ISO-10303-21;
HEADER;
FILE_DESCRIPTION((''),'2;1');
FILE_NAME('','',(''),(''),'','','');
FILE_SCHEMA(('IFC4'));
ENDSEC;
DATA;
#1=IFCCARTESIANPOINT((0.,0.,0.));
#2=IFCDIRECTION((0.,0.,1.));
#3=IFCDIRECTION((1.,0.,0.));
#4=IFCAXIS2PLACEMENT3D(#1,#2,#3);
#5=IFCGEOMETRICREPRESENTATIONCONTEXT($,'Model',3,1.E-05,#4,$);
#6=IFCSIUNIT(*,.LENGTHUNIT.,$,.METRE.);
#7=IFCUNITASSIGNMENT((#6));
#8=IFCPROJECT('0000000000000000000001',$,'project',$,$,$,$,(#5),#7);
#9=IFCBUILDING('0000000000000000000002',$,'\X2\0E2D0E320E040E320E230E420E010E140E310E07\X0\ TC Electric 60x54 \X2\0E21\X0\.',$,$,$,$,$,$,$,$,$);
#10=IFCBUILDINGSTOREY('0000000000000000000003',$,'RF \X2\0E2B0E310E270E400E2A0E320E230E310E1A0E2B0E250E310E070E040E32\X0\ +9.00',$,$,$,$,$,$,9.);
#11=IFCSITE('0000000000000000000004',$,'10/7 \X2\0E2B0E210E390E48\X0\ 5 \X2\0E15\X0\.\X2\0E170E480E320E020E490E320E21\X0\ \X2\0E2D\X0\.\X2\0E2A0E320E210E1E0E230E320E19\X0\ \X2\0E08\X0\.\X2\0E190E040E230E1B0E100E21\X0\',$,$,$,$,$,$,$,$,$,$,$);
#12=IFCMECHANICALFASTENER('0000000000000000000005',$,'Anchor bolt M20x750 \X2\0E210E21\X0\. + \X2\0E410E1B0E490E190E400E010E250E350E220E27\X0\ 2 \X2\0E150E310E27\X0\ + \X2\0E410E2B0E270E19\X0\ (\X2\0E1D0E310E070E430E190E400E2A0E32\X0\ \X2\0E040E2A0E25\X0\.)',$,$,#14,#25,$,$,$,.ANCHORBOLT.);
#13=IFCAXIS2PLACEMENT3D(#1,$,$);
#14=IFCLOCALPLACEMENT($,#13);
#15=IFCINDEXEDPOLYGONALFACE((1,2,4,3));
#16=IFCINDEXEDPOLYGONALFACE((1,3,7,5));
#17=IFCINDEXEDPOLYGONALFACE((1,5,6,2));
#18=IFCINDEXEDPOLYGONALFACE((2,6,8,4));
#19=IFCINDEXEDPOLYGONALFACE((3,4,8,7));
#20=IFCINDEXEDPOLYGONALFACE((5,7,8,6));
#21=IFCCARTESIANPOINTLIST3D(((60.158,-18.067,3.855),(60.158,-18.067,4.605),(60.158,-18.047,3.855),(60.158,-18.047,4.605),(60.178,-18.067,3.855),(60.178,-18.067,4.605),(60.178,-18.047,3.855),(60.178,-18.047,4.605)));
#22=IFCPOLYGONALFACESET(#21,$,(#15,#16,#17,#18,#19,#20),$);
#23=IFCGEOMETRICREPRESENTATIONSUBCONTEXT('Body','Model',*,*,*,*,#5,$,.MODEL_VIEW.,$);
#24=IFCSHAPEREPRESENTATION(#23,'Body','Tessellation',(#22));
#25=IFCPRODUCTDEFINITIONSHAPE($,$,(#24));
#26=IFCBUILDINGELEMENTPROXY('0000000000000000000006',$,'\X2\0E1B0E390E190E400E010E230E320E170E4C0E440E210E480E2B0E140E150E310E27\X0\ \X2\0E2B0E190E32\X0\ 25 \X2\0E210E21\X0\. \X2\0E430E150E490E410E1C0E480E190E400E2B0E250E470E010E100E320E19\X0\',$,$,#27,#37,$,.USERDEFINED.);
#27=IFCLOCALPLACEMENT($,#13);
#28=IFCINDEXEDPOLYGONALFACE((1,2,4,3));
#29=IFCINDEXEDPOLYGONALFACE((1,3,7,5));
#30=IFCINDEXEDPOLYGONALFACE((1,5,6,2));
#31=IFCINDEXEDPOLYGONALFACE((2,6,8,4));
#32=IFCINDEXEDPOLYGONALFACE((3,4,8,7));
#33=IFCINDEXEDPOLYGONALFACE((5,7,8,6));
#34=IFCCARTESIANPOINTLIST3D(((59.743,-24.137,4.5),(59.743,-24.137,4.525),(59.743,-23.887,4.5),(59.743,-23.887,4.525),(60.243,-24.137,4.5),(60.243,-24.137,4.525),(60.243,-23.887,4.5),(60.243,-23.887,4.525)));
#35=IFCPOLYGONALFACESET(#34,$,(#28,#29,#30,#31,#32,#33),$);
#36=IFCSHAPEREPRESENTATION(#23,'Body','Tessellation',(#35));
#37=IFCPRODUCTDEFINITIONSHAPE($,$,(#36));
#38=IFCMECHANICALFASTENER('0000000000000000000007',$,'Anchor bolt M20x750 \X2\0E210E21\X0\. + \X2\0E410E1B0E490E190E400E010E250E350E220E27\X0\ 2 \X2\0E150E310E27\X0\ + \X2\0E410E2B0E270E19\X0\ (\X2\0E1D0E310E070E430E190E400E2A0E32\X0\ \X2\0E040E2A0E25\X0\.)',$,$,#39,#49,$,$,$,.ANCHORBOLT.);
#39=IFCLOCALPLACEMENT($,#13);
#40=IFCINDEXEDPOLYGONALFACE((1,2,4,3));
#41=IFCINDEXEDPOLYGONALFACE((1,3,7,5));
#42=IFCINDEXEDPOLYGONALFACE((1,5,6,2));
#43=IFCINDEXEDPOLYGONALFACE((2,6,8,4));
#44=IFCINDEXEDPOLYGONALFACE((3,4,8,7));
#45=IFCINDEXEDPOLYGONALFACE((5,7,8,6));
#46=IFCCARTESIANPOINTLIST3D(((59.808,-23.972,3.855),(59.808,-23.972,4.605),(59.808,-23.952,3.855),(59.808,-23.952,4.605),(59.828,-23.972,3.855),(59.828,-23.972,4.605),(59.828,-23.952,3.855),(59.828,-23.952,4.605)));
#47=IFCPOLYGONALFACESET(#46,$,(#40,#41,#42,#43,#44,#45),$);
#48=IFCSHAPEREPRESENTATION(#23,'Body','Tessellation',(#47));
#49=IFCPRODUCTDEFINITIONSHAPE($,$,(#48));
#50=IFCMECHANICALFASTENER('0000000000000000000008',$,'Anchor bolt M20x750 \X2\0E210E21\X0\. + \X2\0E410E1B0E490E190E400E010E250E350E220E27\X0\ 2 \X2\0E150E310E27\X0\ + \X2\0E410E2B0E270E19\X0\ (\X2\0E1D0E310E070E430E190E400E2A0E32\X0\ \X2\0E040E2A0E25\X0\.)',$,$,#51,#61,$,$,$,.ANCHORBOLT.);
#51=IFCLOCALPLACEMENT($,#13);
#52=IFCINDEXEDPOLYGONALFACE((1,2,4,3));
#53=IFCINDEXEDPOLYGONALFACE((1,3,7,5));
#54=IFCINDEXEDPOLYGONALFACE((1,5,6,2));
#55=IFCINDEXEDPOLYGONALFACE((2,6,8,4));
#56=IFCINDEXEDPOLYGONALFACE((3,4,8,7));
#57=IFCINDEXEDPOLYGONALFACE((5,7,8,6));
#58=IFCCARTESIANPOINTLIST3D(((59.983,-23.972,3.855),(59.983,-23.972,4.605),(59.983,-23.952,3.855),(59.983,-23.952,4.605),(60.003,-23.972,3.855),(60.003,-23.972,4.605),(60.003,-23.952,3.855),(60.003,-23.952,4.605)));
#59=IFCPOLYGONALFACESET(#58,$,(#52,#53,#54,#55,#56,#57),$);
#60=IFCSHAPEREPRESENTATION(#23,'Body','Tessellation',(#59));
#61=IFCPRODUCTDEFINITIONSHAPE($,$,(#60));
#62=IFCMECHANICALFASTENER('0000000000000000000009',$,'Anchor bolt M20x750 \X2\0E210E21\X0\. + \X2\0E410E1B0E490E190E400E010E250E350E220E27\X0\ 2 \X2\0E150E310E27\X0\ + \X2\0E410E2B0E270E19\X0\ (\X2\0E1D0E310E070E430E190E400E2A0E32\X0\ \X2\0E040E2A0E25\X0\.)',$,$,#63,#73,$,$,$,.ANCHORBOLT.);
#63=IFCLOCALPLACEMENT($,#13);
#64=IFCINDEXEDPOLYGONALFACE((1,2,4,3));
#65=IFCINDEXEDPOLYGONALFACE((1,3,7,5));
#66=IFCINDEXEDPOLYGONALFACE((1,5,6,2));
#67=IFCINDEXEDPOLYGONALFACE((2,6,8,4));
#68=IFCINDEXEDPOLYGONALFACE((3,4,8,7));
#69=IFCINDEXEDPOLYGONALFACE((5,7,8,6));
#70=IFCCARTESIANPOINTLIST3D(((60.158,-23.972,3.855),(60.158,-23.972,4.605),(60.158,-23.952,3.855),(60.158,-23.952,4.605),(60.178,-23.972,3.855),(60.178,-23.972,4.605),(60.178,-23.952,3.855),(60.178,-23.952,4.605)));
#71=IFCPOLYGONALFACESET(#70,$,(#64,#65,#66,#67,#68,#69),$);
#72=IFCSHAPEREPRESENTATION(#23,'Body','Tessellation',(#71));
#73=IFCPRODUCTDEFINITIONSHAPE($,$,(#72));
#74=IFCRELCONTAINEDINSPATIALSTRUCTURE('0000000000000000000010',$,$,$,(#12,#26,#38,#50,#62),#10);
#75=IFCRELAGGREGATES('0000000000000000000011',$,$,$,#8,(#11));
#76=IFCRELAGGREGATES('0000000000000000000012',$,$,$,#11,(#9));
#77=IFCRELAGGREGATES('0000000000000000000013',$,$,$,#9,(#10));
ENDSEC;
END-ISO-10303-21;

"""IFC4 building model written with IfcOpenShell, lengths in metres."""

from ifc_helpers import new_model, si_unit, frame, origin, origin_with_axes, origin_2d, place, context, subcontext, project, spatial, rectangle, extrude, element, save


model = new_model("IFC4")

# Units and contexts
model_context = context("Model", 3, precision=1e-05, world=origin_with_axes())
body_context = subcontext(model_context, "Body", "Model", "MODEL_VIEW")
ifc_project = project(units=[si_unit("LENGTHUNIT", "METRE")], contexts=[model_context])

# Site, building, storey
site = spatial("IfcSite", under=ifc_project, Name="10/7 หมู่ 5 ต.ท่าข้าม อ.สามพราน จ.นครปฐม")
building = spatial("IfcBuilding", under=site, Name="อาคารโกดัง TC Electric 60x54 ม.")
storey = spatial("IfcBuildingStorey", under=building, Name="RF หัวเสารับหลังคา +9.00", Elevation=9.0)

# Mechanical fastener
for number, where, z_axis, x_axis, name in (
    (1, (60.168, -18.057, 3.855), (0.0, 0.0, 1.0), (1.0, 0.0, 0.0), "Anchor bolt M20x750 มม. + แป้นเกลียว 2 ตัว + แหวน (ฝังในเสา คสล.)"),
):
    element("IfcMechanicalFastener", number, at=place(None, frame(where, z_axis=z_axis, x_axis=x_axis)), inside=storey, Name=name, PredefinedType="ANCHORBOLT", context=body_context, shape_type="SweptSolid", body=[
        extrude(rectangle(XDim=0.02, YDim=0.02, at=origin_2d()), origin(), (0.0, 0.0, 1.0), 0.75),
    ])

# Building element proxy
proxy_1_placement = place(None, frame((59.993, -24.012, 4.5), z_axis=(0.0, 0.0, 1.0), x_axis=(1.0, 0.0, 0.0)))
element("IfcBuildingElementProxy", 2, at=proxy_1_placement, inside=storey, Name="ปูนเกราท์ไม่หดตัว หนา 25 มม. ใต้แผ่นเหล็กฐาน", PredefinedType="USERDEFINED", context=body_context, shape_type="SweptSolid", body=[
    extrude(rectangle(XDim=0.5, YDim=0.25, at=origin_2d()), origin(), (0.0, 0.0, 1.0), 0.025),
])

# Mechanical fasteners
for number, where, z_axis, x_axis, name in (
    (3, (59.818, -23.962, 3.855), (0.0, 0.0, 1.0), (1.0, 0.0, 0.0), "Anchor bolt M20x750 มม. + แป้นเกลียว 2 ตัว + แหวน (ฝังในเสา คสล.)"),
    (4, (59.993, -23.962, 3.855), (0.0, 0.0, 1.0), (1.0, 0.0, 0.0), "Anchor bolt M20x750 มม. + แป้นเกลียว 2 ตัว + แหวน (ฝังในเสา คสล.)"),
    (5, (60.168, -23.962, 3.855), (0.0, 0.0, 1.0), (1.0, 0.0, 0.0), "Anchor bolt M20x750 มม. + แป้นเกลียว 2 ตัว + แหวน (ฝังในเสา คสล.)"),
):
    element("IfcMechanicalFastener", number, at=place(None, frame(where, z_axis=z_axis, x_axis=x_axis)), inside=storey, Name=name, PredefinedType="ANCHORBOLT", context=body_context, shape_type="SweptSolid", body=[
        extrude(rectangle(XDim=0.02, YDim=0.02, at=origin_2d()), origin(), (0.0, 0.0, 1.0), 0.75),
    ])

save(model, "model.ifc")
